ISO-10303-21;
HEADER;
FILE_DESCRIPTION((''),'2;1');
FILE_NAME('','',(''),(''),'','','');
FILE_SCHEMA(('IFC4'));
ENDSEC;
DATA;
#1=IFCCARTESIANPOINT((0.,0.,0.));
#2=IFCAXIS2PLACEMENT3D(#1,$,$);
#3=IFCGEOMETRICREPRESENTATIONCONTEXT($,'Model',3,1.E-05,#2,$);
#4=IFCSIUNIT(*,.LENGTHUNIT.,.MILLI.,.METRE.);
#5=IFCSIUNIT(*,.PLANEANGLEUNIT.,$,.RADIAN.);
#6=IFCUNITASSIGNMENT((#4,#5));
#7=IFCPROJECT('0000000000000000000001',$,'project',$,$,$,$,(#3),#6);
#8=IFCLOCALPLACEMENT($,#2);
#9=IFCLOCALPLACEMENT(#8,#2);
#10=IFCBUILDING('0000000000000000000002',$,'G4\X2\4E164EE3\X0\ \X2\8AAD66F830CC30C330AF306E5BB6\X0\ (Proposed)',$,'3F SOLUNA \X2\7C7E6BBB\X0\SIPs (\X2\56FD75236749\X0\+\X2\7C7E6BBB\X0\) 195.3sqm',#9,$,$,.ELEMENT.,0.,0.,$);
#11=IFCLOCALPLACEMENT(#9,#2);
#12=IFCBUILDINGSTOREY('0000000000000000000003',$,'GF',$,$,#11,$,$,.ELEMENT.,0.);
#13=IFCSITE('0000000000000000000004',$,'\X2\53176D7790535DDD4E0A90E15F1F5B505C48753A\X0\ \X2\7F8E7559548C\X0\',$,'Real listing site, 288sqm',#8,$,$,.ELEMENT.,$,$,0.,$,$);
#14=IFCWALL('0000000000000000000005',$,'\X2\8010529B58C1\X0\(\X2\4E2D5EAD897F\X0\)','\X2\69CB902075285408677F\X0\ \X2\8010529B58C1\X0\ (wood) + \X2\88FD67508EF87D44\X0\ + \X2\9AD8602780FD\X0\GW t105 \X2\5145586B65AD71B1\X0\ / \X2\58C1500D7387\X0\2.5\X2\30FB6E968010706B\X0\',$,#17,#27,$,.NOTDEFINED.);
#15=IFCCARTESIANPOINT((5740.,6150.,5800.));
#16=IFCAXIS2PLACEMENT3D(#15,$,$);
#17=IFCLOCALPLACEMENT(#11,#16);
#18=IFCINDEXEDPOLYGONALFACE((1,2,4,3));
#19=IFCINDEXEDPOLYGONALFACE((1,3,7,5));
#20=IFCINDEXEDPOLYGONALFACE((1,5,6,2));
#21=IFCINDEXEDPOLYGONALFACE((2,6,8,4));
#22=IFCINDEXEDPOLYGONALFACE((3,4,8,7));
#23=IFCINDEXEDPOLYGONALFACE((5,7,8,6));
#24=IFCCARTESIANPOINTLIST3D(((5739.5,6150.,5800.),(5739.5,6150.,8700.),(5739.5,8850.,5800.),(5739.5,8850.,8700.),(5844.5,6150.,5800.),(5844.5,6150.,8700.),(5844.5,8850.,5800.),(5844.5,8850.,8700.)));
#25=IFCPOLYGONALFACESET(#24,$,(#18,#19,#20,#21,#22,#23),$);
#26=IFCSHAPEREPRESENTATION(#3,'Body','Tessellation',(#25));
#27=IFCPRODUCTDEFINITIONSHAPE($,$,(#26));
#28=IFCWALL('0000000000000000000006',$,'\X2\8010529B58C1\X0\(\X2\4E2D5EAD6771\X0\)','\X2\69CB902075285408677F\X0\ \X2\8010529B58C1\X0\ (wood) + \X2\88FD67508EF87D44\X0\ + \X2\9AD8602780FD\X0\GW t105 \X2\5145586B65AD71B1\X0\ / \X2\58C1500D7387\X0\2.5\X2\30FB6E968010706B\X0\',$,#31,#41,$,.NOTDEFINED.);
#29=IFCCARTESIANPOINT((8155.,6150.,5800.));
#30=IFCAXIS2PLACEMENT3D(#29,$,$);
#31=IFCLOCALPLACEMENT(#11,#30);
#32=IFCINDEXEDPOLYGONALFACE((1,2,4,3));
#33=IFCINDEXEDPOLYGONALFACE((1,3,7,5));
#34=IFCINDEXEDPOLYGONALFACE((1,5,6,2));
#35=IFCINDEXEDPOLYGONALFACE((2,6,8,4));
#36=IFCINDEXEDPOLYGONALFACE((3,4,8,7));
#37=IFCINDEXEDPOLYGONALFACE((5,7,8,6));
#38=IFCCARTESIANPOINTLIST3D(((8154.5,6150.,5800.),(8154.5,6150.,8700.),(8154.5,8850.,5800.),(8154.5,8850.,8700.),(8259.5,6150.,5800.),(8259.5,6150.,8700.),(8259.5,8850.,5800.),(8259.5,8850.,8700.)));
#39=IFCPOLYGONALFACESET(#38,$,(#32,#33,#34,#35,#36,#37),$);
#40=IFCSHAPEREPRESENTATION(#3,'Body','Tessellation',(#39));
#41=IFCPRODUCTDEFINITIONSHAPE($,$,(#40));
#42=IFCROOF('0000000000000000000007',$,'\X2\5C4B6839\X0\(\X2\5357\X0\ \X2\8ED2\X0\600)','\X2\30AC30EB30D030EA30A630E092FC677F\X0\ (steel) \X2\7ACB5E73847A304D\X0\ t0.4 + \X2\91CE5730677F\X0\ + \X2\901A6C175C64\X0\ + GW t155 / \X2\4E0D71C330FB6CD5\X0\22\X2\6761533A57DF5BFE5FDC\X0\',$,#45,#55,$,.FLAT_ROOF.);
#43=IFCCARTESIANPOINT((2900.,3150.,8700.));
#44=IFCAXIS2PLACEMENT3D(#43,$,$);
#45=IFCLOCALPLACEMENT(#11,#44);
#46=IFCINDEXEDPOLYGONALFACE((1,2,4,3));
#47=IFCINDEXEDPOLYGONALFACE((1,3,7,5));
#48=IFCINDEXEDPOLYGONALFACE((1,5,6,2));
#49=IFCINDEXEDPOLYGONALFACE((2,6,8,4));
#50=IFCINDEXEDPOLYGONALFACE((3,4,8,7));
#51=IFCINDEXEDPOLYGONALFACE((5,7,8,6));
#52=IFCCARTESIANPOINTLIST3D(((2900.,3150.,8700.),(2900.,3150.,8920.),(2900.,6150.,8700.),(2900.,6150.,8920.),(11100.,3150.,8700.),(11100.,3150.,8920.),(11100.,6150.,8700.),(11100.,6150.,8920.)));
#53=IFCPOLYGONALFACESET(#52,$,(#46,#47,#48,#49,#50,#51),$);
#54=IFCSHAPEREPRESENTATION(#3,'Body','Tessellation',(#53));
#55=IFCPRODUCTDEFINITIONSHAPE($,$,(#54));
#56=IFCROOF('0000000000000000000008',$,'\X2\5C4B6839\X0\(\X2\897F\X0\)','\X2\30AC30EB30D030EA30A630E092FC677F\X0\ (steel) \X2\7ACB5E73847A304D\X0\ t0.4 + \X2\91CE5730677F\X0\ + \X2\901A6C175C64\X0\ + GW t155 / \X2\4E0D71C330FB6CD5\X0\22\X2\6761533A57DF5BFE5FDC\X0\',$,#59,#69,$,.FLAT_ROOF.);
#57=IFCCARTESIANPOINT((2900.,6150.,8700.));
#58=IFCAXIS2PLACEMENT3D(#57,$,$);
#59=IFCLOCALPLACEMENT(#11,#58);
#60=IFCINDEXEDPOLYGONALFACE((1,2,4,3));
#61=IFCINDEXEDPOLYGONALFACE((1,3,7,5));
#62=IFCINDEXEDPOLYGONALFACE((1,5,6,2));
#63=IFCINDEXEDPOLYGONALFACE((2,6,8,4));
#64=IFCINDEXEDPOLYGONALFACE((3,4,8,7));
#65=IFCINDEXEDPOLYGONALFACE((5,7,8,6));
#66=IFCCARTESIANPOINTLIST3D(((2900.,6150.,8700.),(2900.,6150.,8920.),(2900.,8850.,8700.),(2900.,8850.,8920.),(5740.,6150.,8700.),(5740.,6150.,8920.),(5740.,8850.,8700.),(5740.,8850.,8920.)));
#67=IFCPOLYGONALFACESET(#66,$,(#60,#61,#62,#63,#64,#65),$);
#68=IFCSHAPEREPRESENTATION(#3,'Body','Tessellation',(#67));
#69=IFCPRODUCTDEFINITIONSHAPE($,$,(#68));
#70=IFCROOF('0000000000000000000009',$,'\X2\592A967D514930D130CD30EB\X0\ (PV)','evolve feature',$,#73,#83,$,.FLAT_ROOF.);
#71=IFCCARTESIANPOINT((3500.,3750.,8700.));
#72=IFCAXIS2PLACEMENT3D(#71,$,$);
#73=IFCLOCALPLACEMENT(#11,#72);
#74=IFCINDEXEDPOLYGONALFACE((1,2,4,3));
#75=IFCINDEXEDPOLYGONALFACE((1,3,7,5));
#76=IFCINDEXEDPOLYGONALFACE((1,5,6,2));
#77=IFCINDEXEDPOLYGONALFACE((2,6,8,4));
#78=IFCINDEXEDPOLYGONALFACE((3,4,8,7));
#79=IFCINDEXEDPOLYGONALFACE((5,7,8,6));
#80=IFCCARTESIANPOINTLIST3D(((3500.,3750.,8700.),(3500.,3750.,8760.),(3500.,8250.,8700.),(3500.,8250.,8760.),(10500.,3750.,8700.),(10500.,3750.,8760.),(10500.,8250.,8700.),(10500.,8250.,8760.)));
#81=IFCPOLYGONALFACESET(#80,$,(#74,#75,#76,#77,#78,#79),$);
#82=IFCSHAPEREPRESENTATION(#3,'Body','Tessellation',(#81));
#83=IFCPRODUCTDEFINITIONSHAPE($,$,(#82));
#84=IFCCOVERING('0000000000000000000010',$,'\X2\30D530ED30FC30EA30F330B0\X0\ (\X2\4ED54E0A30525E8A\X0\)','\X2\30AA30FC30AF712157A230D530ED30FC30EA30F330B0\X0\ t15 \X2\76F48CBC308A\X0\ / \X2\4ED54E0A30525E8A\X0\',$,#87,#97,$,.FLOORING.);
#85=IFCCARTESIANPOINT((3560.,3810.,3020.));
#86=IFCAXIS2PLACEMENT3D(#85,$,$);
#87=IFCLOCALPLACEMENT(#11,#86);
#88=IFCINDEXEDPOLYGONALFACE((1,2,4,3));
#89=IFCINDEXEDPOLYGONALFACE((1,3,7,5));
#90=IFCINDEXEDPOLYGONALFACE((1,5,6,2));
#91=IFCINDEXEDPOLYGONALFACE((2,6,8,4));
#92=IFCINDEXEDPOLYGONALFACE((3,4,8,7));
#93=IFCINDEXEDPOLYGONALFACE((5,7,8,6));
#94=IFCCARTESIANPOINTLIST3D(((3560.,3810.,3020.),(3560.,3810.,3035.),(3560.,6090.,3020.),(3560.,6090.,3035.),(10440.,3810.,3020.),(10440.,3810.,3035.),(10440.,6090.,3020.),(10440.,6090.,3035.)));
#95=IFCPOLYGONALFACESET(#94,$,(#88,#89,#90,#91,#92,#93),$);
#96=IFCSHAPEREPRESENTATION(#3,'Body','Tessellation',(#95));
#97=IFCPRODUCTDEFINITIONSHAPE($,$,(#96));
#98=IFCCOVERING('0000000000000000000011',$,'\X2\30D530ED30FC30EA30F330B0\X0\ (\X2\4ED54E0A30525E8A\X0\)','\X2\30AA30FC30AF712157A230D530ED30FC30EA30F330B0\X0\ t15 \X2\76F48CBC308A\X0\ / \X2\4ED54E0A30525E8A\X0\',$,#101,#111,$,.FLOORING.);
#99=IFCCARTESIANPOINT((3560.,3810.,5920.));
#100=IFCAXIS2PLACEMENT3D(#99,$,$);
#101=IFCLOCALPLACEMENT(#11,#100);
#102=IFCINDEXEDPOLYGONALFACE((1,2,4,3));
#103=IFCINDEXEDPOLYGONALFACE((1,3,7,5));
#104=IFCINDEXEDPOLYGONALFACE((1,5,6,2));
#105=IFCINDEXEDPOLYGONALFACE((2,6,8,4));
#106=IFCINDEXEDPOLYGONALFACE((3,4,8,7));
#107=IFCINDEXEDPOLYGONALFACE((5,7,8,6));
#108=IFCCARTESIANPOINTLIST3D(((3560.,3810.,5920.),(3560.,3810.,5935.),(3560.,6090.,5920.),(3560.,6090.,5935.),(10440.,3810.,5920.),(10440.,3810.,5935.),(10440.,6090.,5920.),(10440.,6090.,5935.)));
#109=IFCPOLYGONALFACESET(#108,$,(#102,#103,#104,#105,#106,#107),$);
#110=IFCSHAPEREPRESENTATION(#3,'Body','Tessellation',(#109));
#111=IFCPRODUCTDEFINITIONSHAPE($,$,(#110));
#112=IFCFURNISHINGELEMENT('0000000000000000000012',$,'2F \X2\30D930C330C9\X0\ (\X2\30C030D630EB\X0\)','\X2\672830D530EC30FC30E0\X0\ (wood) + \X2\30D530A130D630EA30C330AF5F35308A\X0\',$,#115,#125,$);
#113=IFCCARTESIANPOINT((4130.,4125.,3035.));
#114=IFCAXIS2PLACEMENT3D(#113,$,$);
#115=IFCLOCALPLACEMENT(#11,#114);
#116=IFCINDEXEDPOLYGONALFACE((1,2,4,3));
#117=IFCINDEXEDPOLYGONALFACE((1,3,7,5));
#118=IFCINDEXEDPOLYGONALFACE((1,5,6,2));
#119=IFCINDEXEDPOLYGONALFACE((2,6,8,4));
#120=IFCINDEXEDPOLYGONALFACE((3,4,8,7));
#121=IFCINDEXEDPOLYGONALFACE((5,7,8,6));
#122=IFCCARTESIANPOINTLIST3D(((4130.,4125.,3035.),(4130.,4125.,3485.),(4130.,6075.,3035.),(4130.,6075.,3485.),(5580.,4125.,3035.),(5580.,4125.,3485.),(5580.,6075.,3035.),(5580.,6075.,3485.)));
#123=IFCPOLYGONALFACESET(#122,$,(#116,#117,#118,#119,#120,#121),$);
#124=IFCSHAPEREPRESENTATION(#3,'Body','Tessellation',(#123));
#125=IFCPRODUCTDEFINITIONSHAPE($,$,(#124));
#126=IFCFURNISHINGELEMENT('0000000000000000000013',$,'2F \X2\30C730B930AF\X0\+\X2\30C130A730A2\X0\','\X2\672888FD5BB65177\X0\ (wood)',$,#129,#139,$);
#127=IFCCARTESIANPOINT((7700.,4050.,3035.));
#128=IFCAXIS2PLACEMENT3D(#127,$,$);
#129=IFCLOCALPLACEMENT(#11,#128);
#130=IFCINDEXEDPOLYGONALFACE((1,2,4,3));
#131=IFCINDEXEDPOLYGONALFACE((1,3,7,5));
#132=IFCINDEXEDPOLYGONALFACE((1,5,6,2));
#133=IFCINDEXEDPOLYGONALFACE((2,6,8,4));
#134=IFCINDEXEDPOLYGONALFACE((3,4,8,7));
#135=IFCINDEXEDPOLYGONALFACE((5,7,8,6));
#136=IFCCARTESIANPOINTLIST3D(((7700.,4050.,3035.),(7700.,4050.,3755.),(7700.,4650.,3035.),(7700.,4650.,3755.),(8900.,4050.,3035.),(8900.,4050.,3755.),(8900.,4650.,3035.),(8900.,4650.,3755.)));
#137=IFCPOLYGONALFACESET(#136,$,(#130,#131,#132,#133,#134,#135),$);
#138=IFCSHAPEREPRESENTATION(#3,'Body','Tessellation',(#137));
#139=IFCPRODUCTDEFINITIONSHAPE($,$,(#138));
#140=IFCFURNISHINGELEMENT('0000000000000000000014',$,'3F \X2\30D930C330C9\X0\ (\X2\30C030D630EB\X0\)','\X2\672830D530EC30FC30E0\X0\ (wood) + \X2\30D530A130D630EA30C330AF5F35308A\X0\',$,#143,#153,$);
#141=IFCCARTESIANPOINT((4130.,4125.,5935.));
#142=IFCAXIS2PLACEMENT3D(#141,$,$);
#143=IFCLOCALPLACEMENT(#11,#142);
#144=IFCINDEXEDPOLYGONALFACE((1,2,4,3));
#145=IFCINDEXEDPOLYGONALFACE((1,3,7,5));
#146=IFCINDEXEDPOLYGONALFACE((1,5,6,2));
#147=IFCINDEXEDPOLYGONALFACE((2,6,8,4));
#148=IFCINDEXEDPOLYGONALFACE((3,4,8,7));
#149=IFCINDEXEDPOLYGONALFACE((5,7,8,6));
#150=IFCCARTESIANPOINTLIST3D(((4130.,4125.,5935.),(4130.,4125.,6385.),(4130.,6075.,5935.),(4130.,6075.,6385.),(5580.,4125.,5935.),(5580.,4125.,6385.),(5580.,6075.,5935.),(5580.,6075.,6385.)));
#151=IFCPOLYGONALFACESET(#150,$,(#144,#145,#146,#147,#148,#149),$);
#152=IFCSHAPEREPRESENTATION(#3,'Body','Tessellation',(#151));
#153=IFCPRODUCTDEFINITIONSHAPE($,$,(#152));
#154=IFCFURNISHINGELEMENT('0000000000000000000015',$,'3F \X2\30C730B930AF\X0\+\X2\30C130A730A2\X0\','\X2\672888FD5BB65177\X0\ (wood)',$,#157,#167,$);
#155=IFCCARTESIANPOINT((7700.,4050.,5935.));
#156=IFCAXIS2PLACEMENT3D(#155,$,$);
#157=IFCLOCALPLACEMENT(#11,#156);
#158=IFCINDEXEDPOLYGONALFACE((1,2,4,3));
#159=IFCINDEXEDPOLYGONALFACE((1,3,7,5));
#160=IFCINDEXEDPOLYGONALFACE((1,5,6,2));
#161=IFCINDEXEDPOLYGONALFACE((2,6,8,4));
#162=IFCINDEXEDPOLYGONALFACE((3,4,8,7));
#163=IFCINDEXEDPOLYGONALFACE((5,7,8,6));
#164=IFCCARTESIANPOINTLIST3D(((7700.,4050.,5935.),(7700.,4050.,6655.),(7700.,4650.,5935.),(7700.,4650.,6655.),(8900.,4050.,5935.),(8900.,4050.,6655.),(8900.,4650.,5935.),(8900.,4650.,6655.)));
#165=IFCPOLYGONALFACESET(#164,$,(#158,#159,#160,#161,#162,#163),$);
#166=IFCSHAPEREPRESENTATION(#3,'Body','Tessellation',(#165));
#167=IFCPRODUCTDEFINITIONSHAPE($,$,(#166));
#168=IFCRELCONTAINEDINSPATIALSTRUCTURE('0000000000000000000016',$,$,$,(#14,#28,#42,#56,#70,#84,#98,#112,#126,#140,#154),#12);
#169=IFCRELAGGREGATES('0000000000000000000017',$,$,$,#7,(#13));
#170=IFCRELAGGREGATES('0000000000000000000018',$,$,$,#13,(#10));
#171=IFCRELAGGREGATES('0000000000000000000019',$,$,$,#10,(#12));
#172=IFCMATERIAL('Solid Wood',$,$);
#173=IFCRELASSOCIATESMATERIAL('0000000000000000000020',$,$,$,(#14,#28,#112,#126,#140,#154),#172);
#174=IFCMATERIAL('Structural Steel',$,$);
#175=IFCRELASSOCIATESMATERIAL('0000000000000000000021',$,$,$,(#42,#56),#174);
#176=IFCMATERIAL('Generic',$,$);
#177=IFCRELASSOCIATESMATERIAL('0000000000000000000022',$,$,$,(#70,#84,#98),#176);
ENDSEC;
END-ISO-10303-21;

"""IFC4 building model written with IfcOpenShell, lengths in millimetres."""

from ifc_helpers import new_model, si_unit, frame, frame_2d, origin, place, context, project, spatial, rectangle, extrude, material, element, save


model = new_model("IFC4")

# Units and contexts
model_context = context("Model", 3, precision=1e-05, world=origin())
ifc_project = project(units=[si_unit("LENGTHUNIT", "METRE", prefix="MILLI"), si_unit("PLANEANGLEUNIT", "RADIAN")], contexts=[model_context])

# Site, building, storey
site_placement = place(None, origin())
site = spatial("IfcSite", under=ifc_project, at=site_placement, Name="北海道川上郡弟子屈町 美留和", ObjectType="Real listing site, 288sqm", CompositionType="ELEMENT", RefElevation=0.0)
building_placement = place(site_placement, origin())
building = spatial("IfcBuilding", under=site, at=building_placement, Name="G4世代 読書ヌックの家 (Proposed)", ObjectType="3F SOLUNA 籾殻SIPs (国産杉+籾殻) 195.3sqm", CompositionType="ELEMENT", ElevationOfRefHeight=0.0, ElevationOfTerrain=0.0)
storey_placement = place(building_placement, origin())
storey = spatial("IfcBuildingStorey", under=building, at=storey_placement, Name="GF", CompositionType="ELEMENT", Elevation=0.0)

# Shared definitions
ifc_material_1 = material(Name="Solid Wood")

# Walls
wall_1_placement = place(storey_placement, frame((5740.0, 6150.0, 5800.0)))
element("IfcWall", 1, at=wall_1_placement, inside=storey, material=ifc_material_1, Name="耐力壁(中庭西)", Description="構造用合板 耐力壁 (wood) + 製材軸組 + 高性能GW t105 充填断熱 / 壁倍率2.5・準耐火", PredefinedType="NOTDEFINED", context=model_context, shape_type="SweptSolid", body=[
    extrude(rectangle(XDim=105.0, YDim=2700.0, at=frame_2d((52.0, 1350.0))), frame((5740.0, 6150.0, 5800.0)), (0.0, 0.0, 1.0), 2900.0),
])
wall_2_placement = place(storey_placement, frame((8155.0, 6150.0, 5800.0)))
element("IfcWall", 2, at=wall_2_placement, inside=storey, material=ifc_material_1, Name="耐力壁(中庭東)", Description="構造用合板 耐力壁 (wood) + 製材軸組 + 高性能GW t105 充填断熱 / 壁倍率2.5・準耐火", PredefinedType="NOTDEFINED", context=model_context, shape_type="SweptSolid", body=[
    extrude(rectangle(XDim=105.0, YDim=2700.0, at=frame_2d((52.0, 1350.0))), frame((8155.0, 6150.0, 5800.0)), (0.0, 0.0, 1.0), 2900.0),
])

# Roofs
ifc_material_2 = material(Name="Structural Steel")
roof_1_placement = place(storey_placement, frame((2900.0, 3150.0, 8700.0)))
element("IfcRoof", 3, at=roof_1_placement, inside=storey, material=ifc_material_2, Name="屋根(南 軒600)", Description="ガルバリウム鋼板 (steel) 立平葺き t0.4 + 野地板 + 通気層 + GW t155 / 不燃・法22条区域対応", PredefinedType="FLAT_ROOF", context=model_context, shape_type="SweptSolid", body=[
    extrude(rectangle(XDim=8200.0, YDim=3000.0, at=frame_2d((4100.0, 1500.0))), frame((2900.0, 3150.0, 8700.0)), (0.0, 0.0, 1.0), 220.0),
])
roof_2_placement = place(storey_placement, frame((2900.0, 6150.0, 8700.0)))
element("IfcRoof", 4, at=roof_2_placement, inside=storey, material=ifc_material_2, Name="屋根(西)", Description="ガルバリウム鋼板 (steel) 立平葺き t0.4 + 野地板 + 通気層 + GW t155 / 不燃・法22条区域対応", PredefinedType="FLAT_ROOF", context=model_context, shape_type="SweptSolid", body=[
    extrude(rectangle(XDim=2840.0, YDim=2700.0, at=frame_2d((1420.0, 1350.0))), frame((2900.0, 6150.0, 8700.0)), (0.0, 0.0, 1.0), 220.0),
])
ifc_material_3 = material(Name="Generic")
roof_3_placement = place(storey_placement, frame((3500.0, 3750.0, 8700.0)))
element("IfcRoof", 5, at=roof_3_placement, inside=storey, material=ifc_material_3, Name="太陽光パネル (PV)", Description="evolve feature", PredefinedType="FLAT_ROOF", context=model_context, shape_type="SweptSolid", body=[
    extrude(rectangle(XDim=7000.0, YDim=4500.0, at=frame_2d((3500.0, 2250.0))), frame((3500.0, 3750.0, 8700.0)), (0.0, 0.0, 1.0), 60.0),
])

# Coverings
covering_1_placement = place(storey_placement, frame((3560.0, 3810.0, 3020.0)))
element("IfcCovering", 6, at=covering_1_placement, inside=storey, material=ifc_material_3, Name="フローリング (仕上げ床)", Description="オーク無垢フローリング t15 直貼り / 仕上げ床", PredefinedType="FLOORING", context=model_context, shape_type="SweptSolid", body=[
    extrude(rectangle(XDim=6880.0, YDim=2280.0, at=frame_2d((3440.0, 1140.0))), frame((3560.0, 3810.0, 3020.0)), (0.0, 0.0, 1.0), 15.0),
])
covering_2_placement = place(storey_placement, frame((3560.0, 3810.0, 5920.0)))
element("IfcCovering", 7, at=covering_2_placement, inside=storey, material=ifc_material_3, Name="フローリング (仕上げ床)", Description="オーク無垢フローリング t15 直貼り / 仕上げ床", PredefinedType="FLOORING", context=model_context, shape_type="SweptSolid", body=[
    extrude(rectangle(XDim=6880.0, YDim=2280.0, at=frame_2d((3440.0, 1140.0))), frame((3560.0, 3810.0, 5920.0)), (0.0, 0.0, 1.0), 15.0),
])

# Furnishing elements
furnishing_1_placement = place(storey_placement, frame((4130.0, 4125.0, 3035.0)))
element("IfcFurnishingElement", 8, at=furnishing_1_placement, inside=storey, material=ifc_material_1, Name="2F ベッド (ダブル)", Description="木フレーム (wood) + ファブリック張り", context=model_context, shape_type="SweptSolid", body=[
    extrude(rectangle(XDim=1450.0, YDim=1950.0, at=frame_2d((725.0, 975.0))), frame((4130.0, 4125.0, 3035.0)), (0.0, 0.0, 1.0), 450.0),
])
furnishing_2_placement = place(storey_placement, frame((7700.0, 4050.0, 3035.0)))
element("IfcFurnishingElement", 9, at=furnishing_2_placement, inside=storey, material=ifc_material_1, Name="2F デスク+チェア", Description="木製家具 (wood)", context=model_context, shape_type="SweptSolid", body=[
    extrude(rectangle(XDim=1200.0, YDim=600.0, at=frame_2d((600.0, 300.0))), frame((7700.0, 4050.0, 3035.0)), (0.0, 0.0, 1.0), 720.0),
])
furnishing_3_placement = place(storey_placement, frame((4130.0, 4125.0, 5935.0)))
element("IfcFurnishingElement", 10, at=furnishing_3_placement, inside=storey, material=ifc_material_1, Name="3F ベッド (ダブル)", Description="木フレーム (wood) + ファブリック張り", context=model_context, shape_type="SweptSolid", body=[
    extrude(rectangle(XDim=1450.0, YDim=1950.0, at=frame_2d((725.0, 975.0))), frame((4130.0, 4125.0, 5935.0)), (0.0, 0.0, 1.0), 450.0),
])
furnishing_4_placement = place(storey_placement, frame((7700.0, 4050.0, 5935.0)))
element("IfcFurnishingElement", 11, at=furnishing_4_placement, inside=storey, material=ifc_material_1, Name="3F デスク+チェア", Description="木製家具 (wood)", context=model_context, shape_type="SweptSolid", body=[
    extrude(rectangle(XDim=1200.0, YDim=600.0, at=frame_2d((600.0, 300.0))), frame((7700.0, 4050.0, 5935.0)), (0.0, 0.0, 1.0), 720.0),
])

save(model, "model.ifc")
